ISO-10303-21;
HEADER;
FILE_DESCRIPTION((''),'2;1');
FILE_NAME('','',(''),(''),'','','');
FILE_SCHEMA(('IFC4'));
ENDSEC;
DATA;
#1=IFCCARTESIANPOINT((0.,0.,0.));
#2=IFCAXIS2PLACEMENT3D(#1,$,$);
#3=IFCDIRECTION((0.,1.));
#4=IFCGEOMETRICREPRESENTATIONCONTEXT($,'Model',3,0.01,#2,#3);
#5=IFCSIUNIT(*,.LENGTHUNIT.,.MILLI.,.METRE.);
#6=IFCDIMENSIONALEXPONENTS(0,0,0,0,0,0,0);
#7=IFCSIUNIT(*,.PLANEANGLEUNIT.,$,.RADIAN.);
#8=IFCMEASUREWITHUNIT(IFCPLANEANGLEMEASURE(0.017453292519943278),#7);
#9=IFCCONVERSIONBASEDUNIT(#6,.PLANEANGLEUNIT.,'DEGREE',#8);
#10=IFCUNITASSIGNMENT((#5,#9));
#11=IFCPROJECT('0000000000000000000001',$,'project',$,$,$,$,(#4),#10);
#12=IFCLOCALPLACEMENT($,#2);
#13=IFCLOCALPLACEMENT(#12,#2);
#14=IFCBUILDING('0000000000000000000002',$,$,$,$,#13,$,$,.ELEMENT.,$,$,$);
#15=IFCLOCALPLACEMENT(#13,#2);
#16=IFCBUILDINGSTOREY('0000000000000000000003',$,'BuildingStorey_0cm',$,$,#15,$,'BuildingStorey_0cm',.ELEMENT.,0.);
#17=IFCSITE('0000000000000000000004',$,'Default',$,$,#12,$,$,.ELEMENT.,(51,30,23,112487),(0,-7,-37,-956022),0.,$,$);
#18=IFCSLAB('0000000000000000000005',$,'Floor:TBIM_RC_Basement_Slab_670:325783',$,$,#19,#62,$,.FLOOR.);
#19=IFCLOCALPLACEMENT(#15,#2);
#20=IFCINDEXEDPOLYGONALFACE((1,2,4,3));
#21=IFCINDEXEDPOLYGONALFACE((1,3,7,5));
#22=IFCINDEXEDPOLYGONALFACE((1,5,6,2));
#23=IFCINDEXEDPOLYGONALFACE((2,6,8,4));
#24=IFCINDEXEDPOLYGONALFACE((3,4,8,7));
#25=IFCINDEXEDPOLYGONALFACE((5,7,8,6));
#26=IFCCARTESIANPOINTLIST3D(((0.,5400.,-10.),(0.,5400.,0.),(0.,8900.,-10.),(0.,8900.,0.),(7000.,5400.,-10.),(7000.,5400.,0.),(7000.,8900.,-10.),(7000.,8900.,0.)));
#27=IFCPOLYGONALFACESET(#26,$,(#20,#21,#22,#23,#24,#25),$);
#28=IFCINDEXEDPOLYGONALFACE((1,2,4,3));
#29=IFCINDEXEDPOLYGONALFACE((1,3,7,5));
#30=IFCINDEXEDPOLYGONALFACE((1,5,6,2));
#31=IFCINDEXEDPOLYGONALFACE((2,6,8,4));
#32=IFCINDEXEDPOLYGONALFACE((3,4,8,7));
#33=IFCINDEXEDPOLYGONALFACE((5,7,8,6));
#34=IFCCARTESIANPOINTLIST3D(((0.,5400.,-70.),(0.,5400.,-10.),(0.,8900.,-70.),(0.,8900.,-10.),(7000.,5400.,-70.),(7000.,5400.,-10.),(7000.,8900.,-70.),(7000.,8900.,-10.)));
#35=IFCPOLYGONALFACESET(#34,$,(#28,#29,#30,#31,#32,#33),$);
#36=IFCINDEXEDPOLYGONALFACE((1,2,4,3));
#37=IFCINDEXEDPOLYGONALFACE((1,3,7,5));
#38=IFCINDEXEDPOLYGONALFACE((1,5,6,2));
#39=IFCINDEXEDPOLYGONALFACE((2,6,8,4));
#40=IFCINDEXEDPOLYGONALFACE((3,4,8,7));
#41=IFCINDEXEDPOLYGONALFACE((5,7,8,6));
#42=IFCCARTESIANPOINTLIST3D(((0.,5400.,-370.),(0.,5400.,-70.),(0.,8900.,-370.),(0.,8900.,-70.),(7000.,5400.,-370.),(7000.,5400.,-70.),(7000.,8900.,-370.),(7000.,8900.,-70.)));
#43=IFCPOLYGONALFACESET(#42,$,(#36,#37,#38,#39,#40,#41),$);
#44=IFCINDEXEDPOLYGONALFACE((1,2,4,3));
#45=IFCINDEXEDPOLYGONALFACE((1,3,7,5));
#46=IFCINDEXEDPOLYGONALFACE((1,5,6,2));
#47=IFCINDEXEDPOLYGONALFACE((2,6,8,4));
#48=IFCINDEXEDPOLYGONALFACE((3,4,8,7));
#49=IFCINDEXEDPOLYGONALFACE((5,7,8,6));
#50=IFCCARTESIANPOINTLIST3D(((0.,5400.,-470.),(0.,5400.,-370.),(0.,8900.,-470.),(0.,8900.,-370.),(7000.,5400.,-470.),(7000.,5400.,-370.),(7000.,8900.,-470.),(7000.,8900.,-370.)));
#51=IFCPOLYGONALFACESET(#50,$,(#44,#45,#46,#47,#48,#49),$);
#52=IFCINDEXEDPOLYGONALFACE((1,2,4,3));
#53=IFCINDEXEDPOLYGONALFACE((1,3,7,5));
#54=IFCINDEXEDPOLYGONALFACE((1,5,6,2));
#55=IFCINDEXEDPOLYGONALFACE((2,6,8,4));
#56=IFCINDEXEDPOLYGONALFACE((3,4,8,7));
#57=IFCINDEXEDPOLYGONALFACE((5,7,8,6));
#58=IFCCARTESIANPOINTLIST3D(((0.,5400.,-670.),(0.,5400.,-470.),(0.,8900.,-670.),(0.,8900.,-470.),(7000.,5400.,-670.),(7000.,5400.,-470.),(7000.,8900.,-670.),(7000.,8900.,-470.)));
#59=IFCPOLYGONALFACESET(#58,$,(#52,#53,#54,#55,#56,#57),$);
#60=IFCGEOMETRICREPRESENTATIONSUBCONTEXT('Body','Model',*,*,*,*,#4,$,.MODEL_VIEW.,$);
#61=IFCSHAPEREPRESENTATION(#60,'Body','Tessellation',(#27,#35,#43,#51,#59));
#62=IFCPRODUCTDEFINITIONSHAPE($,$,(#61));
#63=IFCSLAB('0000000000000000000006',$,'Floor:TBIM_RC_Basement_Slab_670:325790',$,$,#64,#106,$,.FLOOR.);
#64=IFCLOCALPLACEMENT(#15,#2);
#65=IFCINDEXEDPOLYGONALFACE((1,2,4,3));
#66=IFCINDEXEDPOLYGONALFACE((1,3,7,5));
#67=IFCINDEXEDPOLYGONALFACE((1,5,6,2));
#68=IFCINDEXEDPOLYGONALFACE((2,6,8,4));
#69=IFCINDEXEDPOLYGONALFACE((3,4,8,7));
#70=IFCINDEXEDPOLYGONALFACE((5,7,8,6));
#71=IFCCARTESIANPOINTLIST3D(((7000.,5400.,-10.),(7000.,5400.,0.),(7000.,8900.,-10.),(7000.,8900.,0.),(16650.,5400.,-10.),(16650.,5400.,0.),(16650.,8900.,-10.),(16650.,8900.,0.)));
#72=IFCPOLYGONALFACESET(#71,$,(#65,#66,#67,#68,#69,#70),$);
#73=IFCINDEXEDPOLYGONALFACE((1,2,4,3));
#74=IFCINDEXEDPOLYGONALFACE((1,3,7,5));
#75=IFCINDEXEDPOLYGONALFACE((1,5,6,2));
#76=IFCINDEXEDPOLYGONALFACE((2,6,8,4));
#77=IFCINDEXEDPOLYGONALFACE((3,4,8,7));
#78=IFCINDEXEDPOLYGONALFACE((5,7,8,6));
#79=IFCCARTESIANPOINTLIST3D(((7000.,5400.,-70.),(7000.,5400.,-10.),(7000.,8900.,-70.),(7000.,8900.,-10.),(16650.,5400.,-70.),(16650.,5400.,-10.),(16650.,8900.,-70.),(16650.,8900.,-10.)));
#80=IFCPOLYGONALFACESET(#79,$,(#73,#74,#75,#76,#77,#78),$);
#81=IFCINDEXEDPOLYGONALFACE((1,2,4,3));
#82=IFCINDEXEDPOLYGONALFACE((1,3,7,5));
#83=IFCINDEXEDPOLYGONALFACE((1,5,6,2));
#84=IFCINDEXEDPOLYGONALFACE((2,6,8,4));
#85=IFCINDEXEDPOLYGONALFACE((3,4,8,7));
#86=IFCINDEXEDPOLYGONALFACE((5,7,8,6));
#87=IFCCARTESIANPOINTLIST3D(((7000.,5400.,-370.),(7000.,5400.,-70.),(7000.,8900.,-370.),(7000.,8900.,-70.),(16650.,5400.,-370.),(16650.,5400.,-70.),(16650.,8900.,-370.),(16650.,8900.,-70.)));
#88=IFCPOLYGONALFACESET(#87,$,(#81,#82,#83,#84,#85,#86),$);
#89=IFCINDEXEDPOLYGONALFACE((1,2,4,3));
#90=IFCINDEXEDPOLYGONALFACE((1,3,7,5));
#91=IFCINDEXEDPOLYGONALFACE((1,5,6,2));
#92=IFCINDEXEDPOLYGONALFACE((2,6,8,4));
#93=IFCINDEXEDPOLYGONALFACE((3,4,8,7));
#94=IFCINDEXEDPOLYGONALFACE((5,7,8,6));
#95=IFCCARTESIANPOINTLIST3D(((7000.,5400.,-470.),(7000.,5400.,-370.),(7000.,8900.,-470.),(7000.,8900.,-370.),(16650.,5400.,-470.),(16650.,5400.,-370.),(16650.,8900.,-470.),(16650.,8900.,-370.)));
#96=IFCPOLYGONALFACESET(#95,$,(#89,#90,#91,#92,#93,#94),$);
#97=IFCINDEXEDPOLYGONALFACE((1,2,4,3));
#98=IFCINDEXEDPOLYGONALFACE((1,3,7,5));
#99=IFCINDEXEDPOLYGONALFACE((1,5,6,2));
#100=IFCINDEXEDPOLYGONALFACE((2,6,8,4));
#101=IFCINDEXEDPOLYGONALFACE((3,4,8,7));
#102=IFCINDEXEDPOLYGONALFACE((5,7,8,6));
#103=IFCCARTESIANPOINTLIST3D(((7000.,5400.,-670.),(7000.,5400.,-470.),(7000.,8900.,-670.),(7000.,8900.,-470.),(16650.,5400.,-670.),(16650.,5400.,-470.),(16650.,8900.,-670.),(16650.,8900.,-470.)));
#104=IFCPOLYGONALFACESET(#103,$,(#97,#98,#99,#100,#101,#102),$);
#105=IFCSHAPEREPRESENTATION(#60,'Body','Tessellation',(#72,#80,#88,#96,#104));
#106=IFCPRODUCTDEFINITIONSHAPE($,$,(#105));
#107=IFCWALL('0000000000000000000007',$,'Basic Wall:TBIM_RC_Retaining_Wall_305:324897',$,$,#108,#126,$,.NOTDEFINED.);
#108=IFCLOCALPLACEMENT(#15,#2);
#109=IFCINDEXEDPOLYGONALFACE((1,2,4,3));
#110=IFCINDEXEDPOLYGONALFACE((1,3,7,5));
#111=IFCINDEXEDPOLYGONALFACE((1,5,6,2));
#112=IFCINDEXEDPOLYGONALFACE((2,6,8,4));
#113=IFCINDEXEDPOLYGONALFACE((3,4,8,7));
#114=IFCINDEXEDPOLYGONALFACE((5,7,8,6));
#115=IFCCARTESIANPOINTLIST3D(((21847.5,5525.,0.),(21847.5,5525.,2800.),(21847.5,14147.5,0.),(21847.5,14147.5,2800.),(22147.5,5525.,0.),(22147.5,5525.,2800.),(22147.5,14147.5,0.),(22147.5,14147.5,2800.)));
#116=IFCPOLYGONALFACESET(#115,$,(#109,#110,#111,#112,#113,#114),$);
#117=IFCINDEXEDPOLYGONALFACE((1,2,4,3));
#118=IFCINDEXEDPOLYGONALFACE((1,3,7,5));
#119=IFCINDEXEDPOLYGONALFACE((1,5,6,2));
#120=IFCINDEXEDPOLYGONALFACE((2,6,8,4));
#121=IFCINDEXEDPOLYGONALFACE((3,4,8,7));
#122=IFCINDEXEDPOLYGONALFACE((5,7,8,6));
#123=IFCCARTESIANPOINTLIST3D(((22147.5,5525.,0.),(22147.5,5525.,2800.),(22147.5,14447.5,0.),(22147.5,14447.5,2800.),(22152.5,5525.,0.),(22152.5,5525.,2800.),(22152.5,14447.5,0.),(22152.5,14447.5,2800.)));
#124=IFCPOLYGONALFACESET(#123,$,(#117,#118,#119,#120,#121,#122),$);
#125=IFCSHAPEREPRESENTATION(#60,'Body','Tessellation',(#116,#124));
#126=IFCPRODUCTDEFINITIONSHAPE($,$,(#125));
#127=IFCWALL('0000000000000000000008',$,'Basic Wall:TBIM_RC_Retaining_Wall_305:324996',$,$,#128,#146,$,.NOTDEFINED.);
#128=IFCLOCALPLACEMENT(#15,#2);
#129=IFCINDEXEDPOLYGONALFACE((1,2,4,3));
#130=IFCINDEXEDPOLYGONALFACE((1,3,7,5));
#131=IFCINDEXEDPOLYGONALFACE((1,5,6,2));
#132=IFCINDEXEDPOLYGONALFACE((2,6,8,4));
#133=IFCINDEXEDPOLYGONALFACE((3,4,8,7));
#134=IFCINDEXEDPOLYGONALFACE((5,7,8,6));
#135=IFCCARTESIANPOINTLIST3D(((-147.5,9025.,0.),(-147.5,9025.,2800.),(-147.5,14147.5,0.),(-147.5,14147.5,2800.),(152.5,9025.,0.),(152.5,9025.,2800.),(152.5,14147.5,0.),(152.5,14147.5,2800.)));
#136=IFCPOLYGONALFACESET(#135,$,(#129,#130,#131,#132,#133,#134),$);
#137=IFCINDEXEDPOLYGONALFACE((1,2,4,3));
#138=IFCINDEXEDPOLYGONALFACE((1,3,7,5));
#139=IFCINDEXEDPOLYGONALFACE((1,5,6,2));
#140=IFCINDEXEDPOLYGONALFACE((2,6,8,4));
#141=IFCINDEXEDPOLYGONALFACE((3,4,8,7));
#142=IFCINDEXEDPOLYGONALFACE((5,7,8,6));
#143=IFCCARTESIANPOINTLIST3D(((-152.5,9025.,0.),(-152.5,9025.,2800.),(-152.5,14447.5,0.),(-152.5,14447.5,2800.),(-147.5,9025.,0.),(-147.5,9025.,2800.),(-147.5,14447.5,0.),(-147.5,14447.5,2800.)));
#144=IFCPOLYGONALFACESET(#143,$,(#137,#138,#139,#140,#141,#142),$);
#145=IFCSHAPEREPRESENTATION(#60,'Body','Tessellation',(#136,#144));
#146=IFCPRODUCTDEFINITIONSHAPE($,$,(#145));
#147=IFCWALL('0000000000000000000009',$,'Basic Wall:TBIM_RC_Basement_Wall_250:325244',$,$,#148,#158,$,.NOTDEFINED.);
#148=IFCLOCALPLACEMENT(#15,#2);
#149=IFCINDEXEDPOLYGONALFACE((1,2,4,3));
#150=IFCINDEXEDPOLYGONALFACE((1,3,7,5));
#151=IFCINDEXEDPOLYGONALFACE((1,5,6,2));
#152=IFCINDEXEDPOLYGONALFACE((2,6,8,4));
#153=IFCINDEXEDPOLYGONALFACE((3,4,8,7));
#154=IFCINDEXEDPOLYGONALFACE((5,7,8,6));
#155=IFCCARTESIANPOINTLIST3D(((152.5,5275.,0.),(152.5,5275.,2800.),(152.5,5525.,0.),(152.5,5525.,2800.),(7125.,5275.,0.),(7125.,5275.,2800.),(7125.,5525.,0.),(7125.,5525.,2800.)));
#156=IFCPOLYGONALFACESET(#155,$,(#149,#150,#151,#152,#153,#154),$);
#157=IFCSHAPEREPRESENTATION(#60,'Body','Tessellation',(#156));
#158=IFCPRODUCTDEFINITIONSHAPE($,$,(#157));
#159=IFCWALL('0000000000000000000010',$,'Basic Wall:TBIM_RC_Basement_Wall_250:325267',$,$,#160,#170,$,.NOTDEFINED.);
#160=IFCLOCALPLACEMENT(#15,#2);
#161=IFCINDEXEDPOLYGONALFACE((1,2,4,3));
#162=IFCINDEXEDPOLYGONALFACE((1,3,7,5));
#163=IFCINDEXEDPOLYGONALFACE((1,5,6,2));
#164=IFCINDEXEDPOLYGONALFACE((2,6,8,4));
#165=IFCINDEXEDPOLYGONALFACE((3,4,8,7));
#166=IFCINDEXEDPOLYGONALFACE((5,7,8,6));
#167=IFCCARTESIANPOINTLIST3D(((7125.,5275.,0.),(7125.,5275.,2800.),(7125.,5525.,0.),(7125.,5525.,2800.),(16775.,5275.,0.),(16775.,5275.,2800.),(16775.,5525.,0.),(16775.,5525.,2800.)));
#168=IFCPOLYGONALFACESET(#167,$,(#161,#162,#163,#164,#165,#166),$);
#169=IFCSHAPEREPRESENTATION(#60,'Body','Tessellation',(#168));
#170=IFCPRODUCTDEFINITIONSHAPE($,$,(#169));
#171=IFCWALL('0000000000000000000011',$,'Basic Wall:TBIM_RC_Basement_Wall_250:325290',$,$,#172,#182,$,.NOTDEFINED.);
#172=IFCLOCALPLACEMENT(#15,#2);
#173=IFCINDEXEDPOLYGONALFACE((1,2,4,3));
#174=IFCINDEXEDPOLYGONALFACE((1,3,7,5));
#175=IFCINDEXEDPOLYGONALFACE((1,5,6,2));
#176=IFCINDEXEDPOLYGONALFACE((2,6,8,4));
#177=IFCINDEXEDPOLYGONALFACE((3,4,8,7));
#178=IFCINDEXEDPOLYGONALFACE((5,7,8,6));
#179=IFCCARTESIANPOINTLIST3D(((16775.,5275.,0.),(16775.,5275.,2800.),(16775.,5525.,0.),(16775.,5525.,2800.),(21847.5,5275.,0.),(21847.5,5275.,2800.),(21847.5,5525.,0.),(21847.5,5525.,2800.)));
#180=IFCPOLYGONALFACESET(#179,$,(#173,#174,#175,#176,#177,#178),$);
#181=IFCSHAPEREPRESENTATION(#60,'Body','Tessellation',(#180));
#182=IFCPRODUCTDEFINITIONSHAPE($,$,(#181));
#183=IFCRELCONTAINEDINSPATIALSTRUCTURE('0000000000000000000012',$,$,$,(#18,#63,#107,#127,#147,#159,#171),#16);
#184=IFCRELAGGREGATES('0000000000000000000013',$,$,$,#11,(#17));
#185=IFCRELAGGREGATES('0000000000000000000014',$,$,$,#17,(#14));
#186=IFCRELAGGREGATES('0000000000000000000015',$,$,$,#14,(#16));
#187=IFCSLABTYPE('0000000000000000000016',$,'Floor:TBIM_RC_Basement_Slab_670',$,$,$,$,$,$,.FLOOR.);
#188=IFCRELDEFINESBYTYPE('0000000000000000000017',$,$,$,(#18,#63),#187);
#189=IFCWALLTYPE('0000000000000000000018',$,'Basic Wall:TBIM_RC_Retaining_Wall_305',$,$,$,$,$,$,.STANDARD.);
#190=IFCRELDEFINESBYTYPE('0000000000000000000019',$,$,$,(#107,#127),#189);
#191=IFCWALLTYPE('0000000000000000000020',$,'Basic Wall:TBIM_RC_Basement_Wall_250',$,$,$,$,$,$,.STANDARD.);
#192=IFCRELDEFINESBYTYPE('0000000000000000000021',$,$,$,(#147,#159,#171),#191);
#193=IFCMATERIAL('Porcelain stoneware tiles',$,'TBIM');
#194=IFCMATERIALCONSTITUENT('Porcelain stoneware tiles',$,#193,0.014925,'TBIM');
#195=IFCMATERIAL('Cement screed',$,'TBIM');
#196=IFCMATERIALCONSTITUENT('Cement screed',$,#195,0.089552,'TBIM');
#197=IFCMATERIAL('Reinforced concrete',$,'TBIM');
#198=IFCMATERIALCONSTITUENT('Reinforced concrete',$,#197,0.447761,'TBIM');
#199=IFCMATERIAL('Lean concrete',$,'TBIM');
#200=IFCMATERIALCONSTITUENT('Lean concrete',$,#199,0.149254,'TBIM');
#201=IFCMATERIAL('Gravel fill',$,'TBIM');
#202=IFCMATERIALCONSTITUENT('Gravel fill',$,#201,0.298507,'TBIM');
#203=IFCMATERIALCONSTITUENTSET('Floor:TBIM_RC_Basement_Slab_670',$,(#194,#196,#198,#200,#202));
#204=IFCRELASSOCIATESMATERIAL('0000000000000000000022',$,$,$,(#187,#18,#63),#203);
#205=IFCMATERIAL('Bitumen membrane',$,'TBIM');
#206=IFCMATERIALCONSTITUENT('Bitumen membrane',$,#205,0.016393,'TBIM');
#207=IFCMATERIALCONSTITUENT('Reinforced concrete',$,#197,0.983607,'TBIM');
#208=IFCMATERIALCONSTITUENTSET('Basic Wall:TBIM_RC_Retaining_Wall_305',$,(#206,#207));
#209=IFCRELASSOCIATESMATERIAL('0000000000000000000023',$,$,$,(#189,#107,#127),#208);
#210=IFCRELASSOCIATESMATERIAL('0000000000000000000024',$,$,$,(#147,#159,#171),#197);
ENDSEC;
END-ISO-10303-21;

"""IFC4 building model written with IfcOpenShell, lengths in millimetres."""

from ifc_helpers import new_model, entity, si_unit, converted_unit, direction, frame, origin, place, context, subcontext, project, spatial, indexed_curve, outline, extrude, material, constituent, constituent_set, type_object, element, save


model = new_model("IFC4")

# Units and contexts
model_context = context("Model", 3, precision=0.01, world=origin(), true_north=direction((0.0, 1.0)))
body_context = subcontext(model_context, "Body", "Model", "MODEL_VIEW")
ifc_project = project(units=[si_unit("LENGTHUNIT", "METRE", prefix="MILLI"), converted_unit("PLANEANGLEUNIT", "DEGREE", entity("IfcPlaneAngleMeasure", 0.017453292519943278), si_unit("PLANEANGLEUNIT", "RADIAN"), dimensions=[0, 0, 0, 0, 0, 0, 0])], contexts=[model_context])

# Site, building, storey
site_placement = place(None, origin())
site = spatial("IfcSite", under=ifc_project, at=site_placement, Name="Default", CompositionType="ELEMENT", RefLatitude=(51, 30, 23, 112487), RefLongitude=(0, -7, -37, -956022), RefElevation=0.0)
building_placement = place(site_placement, origin())
building = spatial("IfcBuilding", under=site, at=building_placement, CompositionType="ELEMENT")
storey_placement = place(building_placement, origin())
storey = spatial("IfcBuildingStorey", under=building, at=storey_placement, Name="BuildingStorey_0cm", LongName="BuildingStorey_0cm", CompositionType="ELEMENT", Elevation=0.0)

# Slabs
ifc_material_1 = material(Name="Porcelain stoneware tiles", Category="TBIM")
ifc_constituent_1 = constituent(ifc_material_1, Name="Porcelain stoneware tiles", Category="TBIM", fraction=0.014925)
ifc_material_2 = material(Name="Cement screed", Category="TBIM")
ifc_constituent_2 = constituent(ifc_material_2, Name="Cement screed", Category="TBIM", fraction=0.089552)
ifc_material_3 = material(Name="Reinforced concrete", Category="TBIM")
ifc_constituent_3 = constituent(ifc_material_3, Name="Reinforced concrete", Category="TBIM", fraction=0.447761)
ifc_material_4 = material(Name="Lean concrete", Category="TBIM")
ifc_constituent_4 = constituent(ifc_material_4, Name="Lean concrete", Category="TBIM", fraction=0.149254)
ifc_material_5 = material(Name="Gravel fill", Category="TBIM")
ifc_constituent_5 = constituent(ifc_material_5, Name="Gravel fill", Category="TBIM", fraction=0.298507)
ifc_constituent_set_1 = constituent_set(constituents=[ifc_constituent_1, ifc_constituent_2, ifc_constituent_3, ifc_constituent_4, ifc_constituent_5], Name="Floor:TBIM_RC_Basement_Slab_670")
slab_type = type_object("IfcSlabType", Name="Floor:TBIM_RC_Basement_Slab_670", PredefinedType="FLOOR", material=ifc_constituent_set_1)
slab_1_placement = place(storey_placement, origin())
element("IfcSlab", 1, at=slab_1_placement, inside=storey, type_object=slab_type, material=ifc_constituent_set_1, Name="Floor:TBIM_RC_Basement_Slab_670:325783", PredefinedType="FLOOR", context=body_context, shape_type="SweptSolid", body=[
    extrude(outline(indexed_curve([(-3500.0, -1750.0), (3500.0, -1750.0), (3500.0, 1750.0), (-3500.0, 1750.0), (-3500.0, -1750.0)], self_intersect=False)), frame((3500.0, 7150.0, -10.0), z_axis=(0.0, 0.0, 1.0), x_axis=(-1.0, 0.0, 0.0)), (0.0, 0.0, 1.0), 10.0),
    extrude(outline(indexed_curve([(-3500.0, -1750.0), (3500.0, -1750.0), (3500.0, 1750.0), (-3500.0, 1750.0), (-3500.0, -1750.0)], self_intersect=False)), frame((3500.0, 7150.0, -70.0), z_axis=(0.0, 0.0, 1.0), x_axis=(-1.0, 0.0, 0.0)), (0.0, 0.0, 1.0), 60.0),
    extrude(outline(indexed_curve([(-3500.0, -1750.0), (3500.0, -1750.0), (3500.0, 1750.0), (-3500.0, 1750.0), (-3500.0, -1750.0)], self_intersect=False)), frame((3500.0, 7150.0, -370.0), z_axis=(0.0, 0.0, 1.0), x_axis=(-1.0, 0.0, 0.0)), (0.0, 0.0, 1.0), 300.0),
    extrude(outline(indexed_curve([(-3500.0, -1750.0), (3500.0, -1750.0), (3500.0, 1750.0), (-3500.0, 1750.0), (-3500.0, -1750.0)], self_intersect=False)), frame((3500.0, 7150.0, -470.0), z_axis=(0.0, 0.0, 1.0), x_axis=(-1.0, 0.0, 0.0)), (0.0, 0.0, 1.0), 100.0),
    extrude(outline(indexed_curve([(-3500.0, -1750.0), (3500.0, -1750.0), (3500.0, 1750.0), (-3500.0, 1750.0), (-3500.0, -1750.0)], self_intersect=False)), frame((3500.0, 7150.0, -670.0), z_axis=(0.0, 0.0, 1.0), x_axis=(-1.0, 0.0, 0.0)), (0.0, 0.0, 1.0), 200.0),
])
slab_2_placement = place(storey_placement, origin())
element("IfcSlab", 2, at=slab_2_placement, inside=storey, type_object=slab_type, material=ifc_constituent_set_1, Name="Floor:TBIM_RC_Basement_Slab_670:325790", PredefinedType="FLOOR", context=body_context, shape_type="SweptSolid", body=[
    extrude(outline(indexed_curve([(-4825.0, -1750.0), (4825.0, -1750.0), (4825.0, 1750.0), (-4825.0, 1750.0), (-4825.0, -1750.0)], self_intersect=False)), frame((11825.0, 7150.0, -10.0), z_axis=(0.0, 0.0, 1.0), x_axis=(-1.0, 0.0, 0.0)), (0.0, 0.0, 1.0), 10.0),
    extrude(outline(indexed_curve([(-4825.0, -1750.0), (4825.0, -1750.0), (4825.0, 1750.0), (-4825.0, 1750.0), (-4825.0, -1750.0)], self_intersect=False)), frame((11825.0, 7150.0, -70.0), z_axis=(0.0, 0.0, 1.0), x_axis=(-1.0, 0.0, 0.0)), (0.0, 0.0, 1.0), 60.0),
    extrude(outline(indexed_curve([(-4825.0, -1750.0), (4825.0, -1750.0), (4825.0, 1750.0), (-4825.0, 1750.0), (-4825.0, -1750.0)], self_intersect=False)), frame((11825.0, 7150.0, -370.0), z_axis=(0.0, 0.0, 1.0), x_axis=(-1.0, 0.0, 0.0)), (0.0, 0.0, 1.0), 300.0),
    extrude(outline(indexed_curve([(-4825.0, -1750.0), (4825.0, -1750.0), (4825.0, 1750.0), (-4825.0, 1750.0), (-4825.0, -1750.0)], self_intersect=False)), frame((11825.0, 7150.0, -470.0), z_axis=(0.0, 0.0, 1.0), x_axis=(-1.0, 0.0, 0.0)), (0.0, 0.0, 1.0), 100.0),
    extrude(outline(indexed_curve([(-4825.0, -1750.0), (4825.0, -1750.0), (4825.0, 1750.0), (-4825.0, 1750.0), (-4825.0, -1750.0)], self_intersect=False)), frame((11825.0, 7150.0, -670.0), z_axis=(0.0, 0.0, 1.0), x_axis=(-1.0, 0.0, 0.0)), (0.0, 0.0, 1.0), 200.0),
])

# Walls
ifc_material_6 = material(Name="Bitumen membrane", Category="TBIM")
ifc_constituent_6 = constituent(ifc_material_6, Name="Bitumen membrane", Category="TBIM", fraction=0.016393)
ifc_constituent_7 = constituent(ifc_material_3, Name="Reinforced concrete", Category="TBIM", fraction=0.983607)
ifc_constituent_set_2 = constituent_set(constituents=[ifc_constituent_6, ifc_constituent_7], Name="Basic Wall:TBIM_RC_Retaining_Wall_305")
wall_type_1 = type_object("IfcWallType", Name="Basic Wall:TBIM_RC_Retaining_Wall_305", PredefinedType="STANDARD", material=ifc_constituent_set_2)
wall_1_placement = place(storey_placement, frame((22000.0, 5525.0, 0.0), z_axis=(0.0, 0.0, 1.0), x_axis=(0.0, 1.0, 0.0)))
element("IfcWall", 3, at=wall_1_placement, inside=storey, type_object=wall_type_1, material=ifc_constituent_set_2, Name="Basic Wall:TBIM_RC_Retaining_Wall_305:324897", PredefinedType="NOTDEFINED", context=body_context, shape_type="SweptSolid", body=[
    extrude(outline(indexed_curve([(-150.0, -4311.3), (150.0, -4311.3), (150.0, 4311.3), (-150.0, 4311.3), (-150.0, -4311.3)], self_intersect=False)), frame((4311.3, 2.5, 0.0), z_axis=(0.0, 0.0, 1.0), x_axis=(0.0, -1.0, 0.0)), (0.0, 0.0, 1.0), 2800.0),
    extrude(outline(indexed_curve([(-2.5, -4461.3), (2.5, -4461.3), (2.5, 4461.2), (-2.5, 4461.2), (-2.5, -4461.3)], self_intersect=False)), frame((4461.2, -150.0, 0.0), z_axis=(0.0, 0.0, 1.0), x_axis=(0.0, 1.0, 0.0)), (0.0, 0.0, 1.0), 2800.0),
])
wall_2_placement = place(storey_placement, frame((0.0, 9025.0, 0.0), z_axis=(0.0, 0.0, 1.0), x_axis=(0.0, 1.0, 0.0)))
element("IfcWall", 4, at=wall_2_placement, inside=storey, type_object=wall_type_1, material=ifc_constituent_set_2, Name="Basic Wall:TBIM_RC_Retaining_Wall_305:324996", PredefinedType="NOTDEFINED", context=body_context, shape_type="SweptSolid", body=[
    extrude(outline(indexed_curve([(-150.0, -2561.3), (150.0, -2561.3), (150.0, 2561.3), (-150.0, 2561.3), (-150.0, -2561.3)], self_intersect=False)), frame((2561.3, -2.5, 0.0), z_axis=(0.0, 0.0, 1.0), x_axis=(0.0, 1.0, 0.0)), (0.0, 0.0, 1.0), 2800.0),
    extrude(outline(indexed_curve([(-2.5, -2711.3), (2.5, -2711.3), (2.5, 2711.3), (-2.5, 2711.3), (-2.5, -2711.3)], self_intersect=False)), frame((2711.3, 150.0, 0.0), z_axis=(0.0, 0.0, 1.0), x_axis=(0.0, -1.0, 0.0)), (0.0, 0.0, 1.0), 2800.0),
])
wall_type_2 = type_object("IfcWallType", Name="Basic Wall:TBIM_RC_Basement_Wall_250", PredefinedType="STANDARD")
wall_3_placement = place(storey_placement, frame((152.5, 5400.0, 0.0)))
element("IfcWall", 5, at=wall_3_placement, inside=storey, type_object=wall_type_2, material=ifc_material_3, Name="Basic Wall:TBIM_RC_Basement_Wall_250:325244", PredefinedType="NOTDEFINED", context=body_context, shape_type="SweptSolid", body=[
    extrude(outline(indexed_curve([(6972.5, 125.0), (0.0, 125.0), (0.0, -125.0), (6972.5, -125.0), (6972.5, 125.0)], self_intersect=False)), origin(), (0.0, 0.0, 1.0), 2800.0),
])
wall_4_placement = place(storey_placement, frame((7125.0, 5400.0, 0.0)))
element("IfcWall", 6, at=wall_4_placement, inside=storey, type_object=wall_type_2, material=ifc_material_3, Name="Basic Wall:TBIM_RC_Basement_Wall_250:325267", PredefinedType="NOTDEFINED", context=body_context, shape_type="SweptSolid", body=[
    extrude(outline(indexed_curve([(9650.0, 125.0), (0.0, 125.0), (0.0, -125.0), (9650.0, -125.0), (9650.0, 125.0)], self_intersect=False)), origin(), (0.0, 0.0, 1.0), 2800.0),
])
wall_5_placement = place(storey_placement, frame((16775.0, 5400.0, 0.0)))
element("IfcWall", 7, at=wall_5_placement, inside=storey, type_object=wall_type_2, material=ifc_material_3, Name="Basic Wall:TBIM_RC_Basement_Wall_250:325290", PredefinedType="NOTDEFINED", context=body_context, shape_type="SweptSolid", body=[
    extrude(outline(indexed_curve([(5072.5, 125.0), (0.0, 125.0), (0.0, -125.0), (5072.5, -125.0), (5072.5, 125.0)], self_intersect=False)), origin(), (0.0, 0.0, 1.0), 2800.0),
])

save(model, "model.ifc")
